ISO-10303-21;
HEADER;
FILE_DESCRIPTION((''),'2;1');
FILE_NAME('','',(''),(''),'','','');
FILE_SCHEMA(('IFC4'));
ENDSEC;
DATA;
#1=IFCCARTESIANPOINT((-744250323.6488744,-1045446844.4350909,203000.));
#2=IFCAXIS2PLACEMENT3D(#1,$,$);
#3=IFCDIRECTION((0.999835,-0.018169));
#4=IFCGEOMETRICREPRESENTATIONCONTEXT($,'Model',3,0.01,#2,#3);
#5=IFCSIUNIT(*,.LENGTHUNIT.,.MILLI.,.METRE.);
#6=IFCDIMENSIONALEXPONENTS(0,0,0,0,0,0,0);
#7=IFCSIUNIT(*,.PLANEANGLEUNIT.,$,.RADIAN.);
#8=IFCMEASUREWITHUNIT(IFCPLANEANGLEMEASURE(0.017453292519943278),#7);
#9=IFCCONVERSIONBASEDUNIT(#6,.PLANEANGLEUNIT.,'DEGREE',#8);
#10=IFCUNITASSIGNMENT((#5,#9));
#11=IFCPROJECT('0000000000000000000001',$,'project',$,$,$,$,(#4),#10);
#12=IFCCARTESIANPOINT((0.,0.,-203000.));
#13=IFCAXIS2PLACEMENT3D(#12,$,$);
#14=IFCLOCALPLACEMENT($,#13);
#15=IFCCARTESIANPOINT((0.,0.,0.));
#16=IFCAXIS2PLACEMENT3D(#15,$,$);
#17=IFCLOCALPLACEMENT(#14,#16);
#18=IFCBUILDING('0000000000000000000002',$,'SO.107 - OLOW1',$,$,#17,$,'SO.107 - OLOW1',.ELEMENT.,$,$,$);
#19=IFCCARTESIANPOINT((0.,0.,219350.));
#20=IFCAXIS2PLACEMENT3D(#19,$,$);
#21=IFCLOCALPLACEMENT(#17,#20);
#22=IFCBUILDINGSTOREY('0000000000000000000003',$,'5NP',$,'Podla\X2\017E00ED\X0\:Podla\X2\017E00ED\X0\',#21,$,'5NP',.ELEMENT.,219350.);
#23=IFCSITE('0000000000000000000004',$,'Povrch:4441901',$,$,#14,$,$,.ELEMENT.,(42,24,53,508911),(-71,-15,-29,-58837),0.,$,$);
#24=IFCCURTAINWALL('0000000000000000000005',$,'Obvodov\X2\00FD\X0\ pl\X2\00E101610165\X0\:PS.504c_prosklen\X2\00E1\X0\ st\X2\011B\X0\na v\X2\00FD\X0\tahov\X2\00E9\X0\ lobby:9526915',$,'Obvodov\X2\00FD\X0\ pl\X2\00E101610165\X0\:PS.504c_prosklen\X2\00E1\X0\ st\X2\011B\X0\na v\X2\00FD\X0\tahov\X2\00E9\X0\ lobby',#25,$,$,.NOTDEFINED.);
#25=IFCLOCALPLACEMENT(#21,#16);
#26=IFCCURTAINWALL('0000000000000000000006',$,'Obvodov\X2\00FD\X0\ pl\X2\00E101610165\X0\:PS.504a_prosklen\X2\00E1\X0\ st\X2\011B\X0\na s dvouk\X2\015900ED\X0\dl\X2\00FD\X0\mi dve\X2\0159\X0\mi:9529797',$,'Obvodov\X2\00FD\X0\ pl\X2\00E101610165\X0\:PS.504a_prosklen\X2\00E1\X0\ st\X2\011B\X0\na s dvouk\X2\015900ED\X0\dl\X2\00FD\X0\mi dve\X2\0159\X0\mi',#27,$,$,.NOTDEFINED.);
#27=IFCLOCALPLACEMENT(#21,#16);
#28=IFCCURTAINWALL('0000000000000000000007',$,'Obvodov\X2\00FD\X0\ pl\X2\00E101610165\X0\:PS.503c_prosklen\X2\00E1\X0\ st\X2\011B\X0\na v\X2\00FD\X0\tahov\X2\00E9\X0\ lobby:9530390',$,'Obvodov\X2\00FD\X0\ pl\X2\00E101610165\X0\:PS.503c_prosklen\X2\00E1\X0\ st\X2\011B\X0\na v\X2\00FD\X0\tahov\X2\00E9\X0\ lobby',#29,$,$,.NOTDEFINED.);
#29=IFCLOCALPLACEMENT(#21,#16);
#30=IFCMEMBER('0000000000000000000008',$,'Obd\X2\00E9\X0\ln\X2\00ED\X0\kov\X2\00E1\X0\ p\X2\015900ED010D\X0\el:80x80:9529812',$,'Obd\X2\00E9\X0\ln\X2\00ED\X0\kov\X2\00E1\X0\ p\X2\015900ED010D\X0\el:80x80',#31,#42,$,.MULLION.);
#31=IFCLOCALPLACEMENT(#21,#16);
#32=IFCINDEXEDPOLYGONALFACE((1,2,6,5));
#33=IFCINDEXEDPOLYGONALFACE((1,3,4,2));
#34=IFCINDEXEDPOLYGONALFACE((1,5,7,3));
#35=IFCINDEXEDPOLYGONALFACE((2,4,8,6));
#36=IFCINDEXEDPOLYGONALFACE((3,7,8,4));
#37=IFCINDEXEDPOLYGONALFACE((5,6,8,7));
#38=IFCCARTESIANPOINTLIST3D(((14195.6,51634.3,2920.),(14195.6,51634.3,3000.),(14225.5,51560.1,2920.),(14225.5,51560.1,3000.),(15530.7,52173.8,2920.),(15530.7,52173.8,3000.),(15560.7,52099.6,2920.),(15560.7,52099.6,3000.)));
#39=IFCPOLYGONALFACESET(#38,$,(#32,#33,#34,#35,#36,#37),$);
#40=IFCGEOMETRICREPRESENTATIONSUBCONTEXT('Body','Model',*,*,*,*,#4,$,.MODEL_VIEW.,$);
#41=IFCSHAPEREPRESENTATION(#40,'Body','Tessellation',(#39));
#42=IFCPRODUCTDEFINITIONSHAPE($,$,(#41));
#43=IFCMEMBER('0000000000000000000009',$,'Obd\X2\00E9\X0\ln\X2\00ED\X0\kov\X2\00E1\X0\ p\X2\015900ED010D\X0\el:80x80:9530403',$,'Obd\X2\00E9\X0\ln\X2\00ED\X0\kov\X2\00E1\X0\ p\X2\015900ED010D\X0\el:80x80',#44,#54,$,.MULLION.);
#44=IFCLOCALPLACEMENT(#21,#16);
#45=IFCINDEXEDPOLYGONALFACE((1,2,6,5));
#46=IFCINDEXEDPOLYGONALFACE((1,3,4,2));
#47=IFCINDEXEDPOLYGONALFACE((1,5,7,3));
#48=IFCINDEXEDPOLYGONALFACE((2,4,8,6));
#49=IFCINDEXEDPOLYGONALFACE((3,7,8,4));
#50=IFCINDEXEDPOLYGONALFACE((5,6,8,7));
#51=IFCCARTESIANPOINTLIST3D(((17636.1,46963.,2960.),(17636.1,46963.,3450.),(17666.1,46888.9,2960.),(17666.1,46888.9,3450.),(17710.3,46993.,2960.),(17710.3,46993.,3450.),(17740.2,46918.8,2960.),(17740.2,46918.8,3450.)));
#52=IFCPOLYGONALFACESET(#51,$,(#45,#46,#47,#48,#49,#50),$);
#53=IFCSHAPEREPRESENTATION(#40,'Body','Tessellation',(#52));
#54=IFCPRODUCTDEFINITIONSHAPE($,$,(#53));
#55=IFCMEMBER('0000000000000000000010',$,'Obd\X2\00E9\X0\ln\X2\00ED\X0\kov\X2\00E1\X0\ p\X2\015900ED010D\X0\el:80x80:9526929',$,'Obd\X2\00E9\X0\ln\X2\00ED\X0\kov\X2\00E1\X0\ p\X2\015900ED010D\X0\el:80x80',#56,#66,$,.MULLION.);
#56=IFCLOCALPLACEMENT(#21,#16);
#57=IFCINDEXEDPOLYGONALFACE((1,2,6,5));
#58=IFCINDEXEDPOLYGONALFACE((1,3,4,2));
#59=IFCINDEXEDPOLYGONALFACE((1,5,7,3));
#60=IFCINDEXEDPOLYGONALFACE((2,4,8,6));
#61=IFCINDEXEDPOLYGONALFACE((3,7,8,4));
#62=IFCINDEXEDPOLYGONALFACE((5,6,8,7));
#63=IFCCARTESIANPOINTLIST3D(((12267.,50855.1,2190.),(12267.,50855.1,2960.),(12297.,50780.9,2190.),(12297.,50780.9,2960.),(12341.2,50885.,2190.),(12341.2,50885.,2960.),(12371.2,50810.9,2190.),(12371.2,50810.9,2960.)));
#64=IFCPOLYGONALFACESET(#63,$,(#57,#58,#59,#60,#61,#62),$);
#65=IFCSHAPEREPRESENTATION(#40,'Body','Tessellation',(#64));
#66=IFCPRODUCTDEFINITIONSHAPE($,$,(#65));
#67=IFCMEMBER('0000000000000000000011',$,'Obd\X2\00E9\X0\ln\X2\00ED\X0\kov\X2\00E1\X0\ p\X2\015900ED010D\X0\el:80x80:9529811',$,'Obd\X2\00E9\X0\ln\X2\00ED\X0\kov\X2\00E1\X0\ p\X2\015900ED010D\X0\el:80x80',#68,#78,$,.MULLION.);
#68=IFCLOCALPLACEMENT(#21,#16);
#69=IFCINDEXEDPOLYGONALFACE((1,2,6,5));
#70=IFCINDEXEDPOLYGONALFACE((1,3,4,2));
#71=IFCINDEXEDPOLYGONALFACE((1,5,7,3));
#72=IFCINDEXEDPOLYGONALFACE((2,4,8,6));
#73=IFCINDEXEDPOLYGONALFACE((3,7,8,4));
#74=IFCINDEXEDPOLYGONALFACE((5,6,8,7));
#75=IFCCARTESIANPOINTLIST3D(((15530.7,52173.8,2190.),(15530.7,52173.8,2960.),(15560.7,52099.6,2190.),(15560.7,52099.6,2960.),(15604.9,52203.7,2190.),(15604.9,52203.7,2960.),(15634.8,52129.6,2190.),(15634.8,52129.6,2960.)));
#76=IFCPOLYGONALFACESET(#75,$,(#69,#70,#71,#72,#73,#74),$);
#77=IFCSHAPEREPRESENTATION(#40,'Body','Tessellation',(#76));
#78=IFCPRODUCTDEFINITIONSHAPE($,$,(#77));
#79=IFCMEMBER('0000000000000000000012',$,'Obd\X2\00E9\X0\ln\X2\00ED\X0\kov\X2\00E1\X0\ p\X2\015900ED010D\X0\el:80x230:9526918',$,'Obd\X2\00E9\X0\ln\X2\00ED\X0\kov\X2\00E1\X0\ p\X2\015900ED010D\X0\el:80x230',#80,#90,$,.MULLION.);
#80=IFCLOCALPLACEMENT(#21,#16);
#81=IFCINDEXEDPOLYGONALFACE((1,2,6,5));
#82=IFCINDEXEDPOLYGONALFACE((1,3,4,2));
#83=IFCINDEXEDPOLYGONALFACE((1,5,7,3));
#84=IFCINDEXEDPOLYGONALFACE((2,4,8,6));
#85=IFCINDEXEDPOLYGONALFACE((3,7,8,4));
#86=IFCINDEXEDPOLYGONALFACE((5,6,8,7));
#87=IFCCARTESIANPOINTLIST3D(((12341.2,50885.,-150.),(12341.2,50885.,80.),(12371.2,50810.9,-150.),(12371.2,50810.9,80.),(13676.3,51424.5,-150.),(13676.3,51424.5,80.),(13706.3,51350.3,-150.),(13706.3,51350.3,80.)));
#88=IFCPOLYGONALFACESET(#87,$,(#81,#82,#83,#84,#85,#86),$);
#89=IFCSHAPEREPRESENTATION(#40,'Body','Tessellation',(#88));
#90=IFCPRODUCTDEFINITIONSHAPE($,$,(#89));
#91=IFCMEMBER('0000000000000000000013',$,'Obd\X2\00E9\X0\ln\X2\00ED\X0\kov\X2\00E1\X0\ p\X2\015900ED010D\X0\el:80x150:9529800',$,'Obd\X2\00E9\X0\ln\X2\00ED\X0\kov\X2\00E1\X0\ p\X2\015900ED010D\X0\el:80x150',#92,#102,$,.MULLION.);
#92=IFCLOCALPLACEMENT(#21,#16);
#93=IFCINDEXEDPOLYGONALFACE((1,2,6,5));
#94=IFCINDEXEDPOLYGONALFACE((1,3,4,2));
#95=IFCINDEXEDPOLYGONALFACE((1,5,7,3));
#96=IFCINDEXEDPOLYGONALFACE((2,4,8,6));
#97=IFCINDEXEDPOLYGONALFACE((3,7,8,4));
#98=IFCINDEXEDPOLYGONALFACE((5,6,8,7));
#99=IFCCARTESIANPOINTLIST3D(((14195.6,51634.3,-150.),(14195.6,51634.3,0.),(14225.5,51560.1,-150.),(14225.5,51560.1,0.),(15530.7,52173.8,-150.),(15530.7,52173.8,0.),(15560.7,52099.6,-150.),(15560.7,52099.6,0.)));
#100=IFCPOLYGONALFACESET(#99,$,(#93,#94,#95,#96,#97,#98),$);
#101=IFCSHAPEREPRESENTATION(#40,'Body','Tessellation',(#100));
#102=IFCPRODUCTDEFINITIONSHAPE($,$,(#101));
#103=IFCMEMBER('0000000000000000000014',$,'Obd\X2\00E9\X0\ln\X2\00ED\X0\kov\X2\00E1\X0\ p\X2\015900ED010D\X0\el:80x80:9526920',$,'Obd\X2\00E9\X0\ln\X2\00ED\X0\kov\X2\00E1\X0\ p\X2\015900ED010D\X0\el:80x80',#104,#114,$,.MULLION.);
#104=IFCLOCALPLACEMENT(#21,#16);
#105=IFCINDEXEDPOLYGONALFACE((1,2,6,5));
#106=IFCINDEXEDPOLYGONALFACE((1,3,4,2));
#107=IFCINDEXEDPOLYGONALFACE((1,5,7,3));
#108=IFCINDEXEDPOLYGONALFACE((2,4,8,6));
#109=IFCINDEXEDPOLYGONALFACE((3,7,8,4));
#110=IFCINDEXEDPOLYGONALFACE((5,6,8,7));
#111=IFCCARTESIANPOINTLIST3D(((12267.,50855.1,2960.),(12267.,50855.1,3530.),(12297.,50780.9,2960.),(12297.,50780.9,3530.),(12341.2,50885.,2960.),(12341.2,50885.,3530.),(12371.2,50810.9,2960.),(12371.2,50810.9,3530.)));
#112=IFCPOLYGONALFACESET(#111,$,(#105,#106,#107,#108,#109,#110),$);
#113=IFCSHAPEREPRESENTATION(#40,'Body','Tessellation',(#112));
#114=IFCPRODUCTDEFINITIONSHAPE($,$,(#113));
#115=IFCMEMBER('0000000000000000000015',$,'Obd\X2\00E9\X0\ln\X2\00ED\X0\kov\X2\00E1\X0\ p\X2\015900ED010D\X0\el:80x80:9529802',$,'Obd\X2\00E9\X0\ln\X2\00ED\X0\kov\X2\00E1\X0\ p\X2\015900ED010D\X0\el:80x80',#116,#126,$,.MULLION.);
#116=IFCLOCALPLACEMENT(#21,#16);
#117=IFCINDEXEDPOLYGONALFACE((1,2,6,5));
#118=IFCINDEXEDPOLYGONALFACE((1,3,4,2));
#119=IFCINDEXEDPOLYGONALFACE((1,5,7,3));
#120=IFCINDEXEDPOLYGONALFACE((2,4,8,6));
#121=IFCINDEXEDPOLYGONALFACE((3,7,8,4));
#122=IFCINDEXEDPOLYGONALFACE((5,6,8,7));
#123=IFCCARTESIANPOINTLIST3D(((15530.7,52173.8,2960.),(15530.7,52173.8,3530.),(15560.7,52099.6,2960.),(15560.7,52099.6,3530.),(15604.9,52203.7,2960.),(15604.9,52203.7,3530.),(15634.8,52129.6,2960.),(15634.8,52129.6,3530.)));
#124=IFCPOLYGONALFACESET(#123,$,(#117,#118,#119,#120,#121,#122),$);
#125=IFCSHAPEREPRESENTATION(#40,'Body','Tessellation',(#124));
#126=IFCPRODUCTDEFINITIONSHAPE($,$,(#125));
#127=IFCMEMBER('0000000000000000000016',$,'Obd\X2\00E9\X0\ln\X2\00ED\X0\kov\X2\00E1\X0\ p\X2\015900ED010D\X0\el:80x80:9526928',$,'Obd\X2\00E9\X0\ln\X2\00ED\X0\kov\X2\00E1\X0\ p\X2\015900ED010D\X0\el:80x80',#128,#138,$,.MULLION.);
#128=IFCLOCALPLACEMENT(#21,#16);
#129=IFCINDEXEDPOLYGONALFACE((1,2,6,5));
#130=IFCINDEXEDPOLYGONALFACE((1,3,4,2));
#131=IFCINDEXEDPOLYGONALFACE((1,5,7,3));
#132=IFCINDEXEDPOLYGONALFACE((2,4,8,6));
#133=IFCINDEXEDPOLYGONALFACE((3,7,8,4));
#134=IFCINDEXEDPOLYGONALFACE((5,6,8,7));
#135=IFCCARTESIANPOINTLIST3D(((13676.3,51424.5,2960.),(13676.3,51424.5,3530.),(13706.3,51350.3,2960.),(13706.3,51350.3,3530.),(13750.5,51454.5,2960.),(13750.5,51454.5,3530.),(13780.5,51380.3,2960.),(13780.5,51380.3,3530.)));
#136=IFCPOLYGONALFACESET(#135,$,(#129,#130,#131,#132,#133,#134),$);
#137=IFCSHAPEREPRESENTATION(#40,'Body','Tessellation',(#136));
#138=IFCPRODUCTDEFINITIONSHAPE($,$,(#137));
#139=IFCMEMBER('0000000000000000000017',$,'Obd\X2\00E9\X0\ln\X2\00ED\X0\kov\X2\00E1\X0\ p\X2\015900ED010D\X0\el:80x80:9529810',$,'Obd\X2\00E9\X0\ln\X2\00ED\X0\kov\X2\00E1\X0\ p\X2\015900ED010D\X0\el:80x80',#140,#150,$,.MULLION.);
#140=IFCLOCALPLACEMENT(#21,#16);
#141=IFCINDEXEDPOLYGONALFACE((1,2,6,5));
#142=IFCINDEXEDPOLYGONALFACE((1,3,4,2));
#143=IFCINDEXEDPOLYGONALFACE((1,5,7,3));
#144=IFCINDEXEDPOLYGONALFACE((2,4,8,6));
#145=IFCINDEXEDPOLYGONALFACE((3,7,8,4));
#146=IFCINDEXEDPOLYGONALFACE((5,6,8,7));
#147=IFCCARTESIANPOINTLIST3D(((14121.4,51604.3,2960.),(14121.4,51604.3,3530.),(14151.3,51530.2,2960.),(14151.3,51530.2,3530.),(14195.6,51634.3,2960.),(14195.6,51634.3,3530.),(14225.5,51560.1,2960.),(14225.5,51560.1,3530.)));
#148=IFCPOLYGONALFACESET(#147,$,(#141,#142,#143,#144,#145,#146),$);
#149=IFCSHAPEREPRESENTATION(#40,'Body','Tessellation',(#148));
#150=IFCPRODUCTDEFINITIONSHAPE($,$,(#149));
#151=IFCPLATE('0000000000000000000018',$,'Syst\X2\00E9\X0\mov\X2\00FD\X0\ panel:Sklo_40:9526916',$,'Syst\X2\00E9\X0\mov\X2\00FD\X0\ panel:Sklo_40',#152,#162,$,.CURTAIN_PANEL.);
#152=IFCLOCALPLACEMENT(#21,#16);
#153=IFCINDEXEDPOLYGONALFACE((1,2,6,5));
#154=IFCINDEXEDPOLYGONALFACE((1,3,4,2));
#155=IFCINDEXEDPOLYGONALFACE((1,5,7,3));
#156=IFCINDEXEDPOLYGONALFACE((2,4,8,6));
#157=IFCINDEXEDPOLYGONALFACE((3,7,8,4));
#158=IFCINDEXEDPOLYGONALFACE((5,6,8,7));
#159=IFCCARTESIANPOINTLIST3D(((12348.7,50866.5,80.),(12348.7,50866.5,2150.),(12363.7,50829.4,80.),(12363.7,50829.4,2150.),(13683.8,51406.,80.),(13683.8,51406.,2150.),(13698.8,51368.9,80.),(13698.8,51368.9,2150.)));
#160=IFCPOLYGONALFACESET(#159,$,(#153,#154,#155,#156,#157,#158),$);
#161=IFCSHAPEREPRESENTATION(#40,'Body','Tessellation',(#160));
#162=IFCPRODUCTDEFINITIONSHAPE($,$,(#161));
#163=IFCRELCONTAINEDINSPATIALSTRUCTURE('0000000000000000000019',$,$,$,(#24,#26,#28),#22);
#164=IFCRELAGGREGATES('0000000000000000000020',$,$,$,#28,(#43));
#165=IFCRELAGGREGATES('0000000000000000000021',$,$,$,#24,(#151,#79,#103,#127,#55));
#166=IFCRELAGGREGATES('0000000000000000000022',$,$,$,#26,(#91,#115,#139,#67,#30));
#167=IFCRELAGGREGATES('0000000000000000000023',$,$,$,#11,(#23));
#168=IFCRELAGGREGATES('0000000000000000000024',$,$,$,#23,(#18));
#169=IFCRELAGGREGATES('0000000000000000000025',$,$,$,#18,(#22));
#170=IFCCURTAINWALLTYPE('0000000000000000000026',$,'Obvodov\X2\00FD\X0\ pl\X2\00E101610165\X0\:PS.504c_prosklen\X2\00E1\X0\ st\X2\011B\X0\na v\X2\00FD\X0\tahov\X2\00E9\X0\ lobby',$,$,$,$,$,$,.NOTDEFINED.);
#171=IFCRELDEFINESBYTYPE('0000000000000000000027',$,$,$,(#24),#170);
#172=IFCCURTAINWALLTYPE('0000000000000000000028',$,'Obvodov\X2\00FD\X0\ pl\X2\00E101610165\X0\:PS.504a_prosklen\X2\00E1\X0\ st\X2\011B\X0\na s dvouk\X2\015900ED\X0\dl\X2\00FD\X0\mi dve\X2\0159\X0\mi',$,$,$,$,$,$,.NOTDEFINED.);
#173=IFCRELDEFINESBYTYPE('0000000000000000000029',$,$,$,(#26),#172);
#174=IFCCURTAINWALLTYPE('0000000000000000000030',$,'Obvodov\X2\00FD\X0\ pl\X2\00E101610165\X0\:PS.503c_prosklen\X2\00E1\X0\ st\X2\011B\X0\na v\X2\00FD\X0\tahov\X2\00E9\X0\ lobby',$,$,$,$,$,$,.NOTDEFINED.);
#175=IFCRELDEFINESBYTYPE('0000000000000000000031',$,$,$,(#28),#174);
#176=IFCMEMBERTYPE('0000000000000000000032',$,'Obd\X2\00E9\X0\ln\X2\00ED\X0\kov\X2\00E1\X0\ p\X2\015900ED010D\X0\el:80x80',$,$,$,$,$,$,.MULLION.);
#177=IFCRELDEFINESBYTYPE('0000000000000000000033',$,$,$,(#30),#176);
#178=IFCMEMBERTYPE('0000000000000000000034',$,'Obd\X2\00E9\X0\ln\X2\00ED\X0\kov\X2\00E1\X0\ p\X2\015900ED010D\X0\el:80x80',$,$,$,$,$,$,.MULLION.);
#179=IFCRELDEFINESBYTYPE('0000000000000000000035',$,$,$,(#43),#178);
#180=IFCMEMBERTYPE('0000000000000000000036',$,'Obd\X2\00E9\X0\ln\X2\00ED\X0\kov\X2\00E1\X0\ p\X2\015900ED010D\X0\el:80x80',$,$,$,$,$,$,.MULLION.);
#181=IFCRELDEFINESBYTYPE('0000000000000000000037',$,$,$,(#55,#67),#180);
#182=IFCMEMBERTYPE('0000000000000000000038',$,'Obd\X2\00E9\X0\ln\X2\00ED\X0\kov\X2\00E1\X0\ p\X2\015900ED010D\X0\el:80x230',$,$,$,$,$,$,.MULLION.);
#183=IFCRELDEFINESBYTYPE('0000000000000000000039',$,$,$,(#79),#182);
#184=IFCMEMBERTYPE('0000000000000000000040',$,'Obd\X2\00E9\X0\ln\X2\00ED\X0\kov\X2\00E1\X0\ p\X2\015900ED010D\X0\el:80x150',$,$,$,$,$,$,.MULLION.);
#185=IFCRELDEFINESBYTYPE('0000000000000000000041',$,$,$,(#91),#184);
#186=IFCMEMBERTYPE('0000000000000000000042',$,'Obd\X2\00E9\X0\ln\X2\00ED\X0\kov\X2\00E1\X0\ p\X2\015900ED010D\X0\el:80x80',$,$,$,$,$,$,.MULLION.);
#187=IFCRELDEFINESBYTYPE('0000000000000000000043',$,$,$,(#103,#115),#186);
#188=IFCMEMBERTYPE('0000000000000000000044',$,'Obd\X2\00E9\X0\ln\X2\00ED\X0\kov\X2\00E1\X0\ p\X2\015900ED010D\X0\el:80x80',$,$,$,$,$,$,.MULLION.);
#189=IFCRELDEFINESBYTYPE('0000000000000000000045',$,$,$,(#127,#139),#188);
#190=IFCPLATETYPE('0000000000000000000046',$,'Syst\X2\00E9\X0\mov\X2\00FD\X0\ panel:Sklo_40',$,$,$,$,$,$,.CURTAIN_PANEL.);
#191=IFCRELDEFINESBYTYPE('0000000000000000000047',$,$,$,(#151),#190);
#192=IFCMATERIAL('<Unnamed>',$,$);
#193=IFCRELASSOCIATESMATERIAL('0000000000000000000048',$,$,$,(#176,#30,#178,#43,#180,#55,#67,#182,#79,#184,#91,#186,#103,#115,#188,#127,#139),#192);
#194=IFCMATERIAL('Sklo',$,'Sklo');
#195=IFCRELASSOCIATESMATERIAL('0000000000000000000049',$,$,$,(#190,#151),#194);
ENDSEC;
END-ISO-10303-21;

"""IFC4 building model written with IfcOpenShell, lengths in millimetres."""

from ifc_helpers import new_model, entity, si_unit, converted_unit, direction, frame, origin, place, context, subcontext, project, spatial, indexed_curve, outline, extrude, source, transform, mapped, material, type_object, type_shapes, element, aggregate, save


model = new_model("IFC4")

# Units and contexts
model_context = context("Model", 3, precision=0.01, world=frame((-744250323.6488744, -1045446844.4350909, 203000.0)), true_north=direction((0.999835, -0.018169)))
body_context = subcontext(model_context, "Body", "Model", "MODEL_VIEW")
ifc_project = project(units=[si_unit("LENGTHUNIT", "METRE", prefix="MILLI"), converted_unit("PLANEANGLEUNIT", "DEGREE", entity("IfcPlaneAngleMeasure", 0.017453292519943278), si_unit("PLANEANGLEUNIT", "RADIAN"), dimensions=[0, 0, 0, 0, 0, 0, 0])], contexts=[model_context])

# Site, building, storey
site_placement = place(None, frame((0.0, 0.0, -203000.0)))
site = spatial("IfcSite", under=ifc_project, at=site_placement, Name="Povrch:4441901", CompositionType="ELEMENT", RefLatitude=(42, 24, 53, 508911), RefLongitude=(-71, -15, -29, -58837), RefElevation=0.0)
building_placement = place(site_placement, origin())
building = spatial("IfcBuilding", under=site, at=building_placement, Name="SO.107 - OLOW1", LongName="SO.107 - OLOW1", CompositionType="ELEMENT")
storey_placement = place(building_placement, frame((0.0, 0.0, 219350.0)))
storey = spatial("IfcBuildingStorey", under=building, at=storey_placement, Name="5NP", ObjectType="Podlaží:Podlaží", LongName="5NP", CompositionType="ELEMENT", Elevation=219350.0)

# Curtain walls
curtain_wall_type_1 = type_object("IfcCurtainWallType", Name="Obvodový plášť:PS.504c_prosklená stěna výtahové lobby", PredefinedType="NOTDEFINED")
curtain_wall_1_placement = place(storey_placement, frame((0.0, 0.0, -219350.0)))
curtain_wall_1 = element("IfcCurtainWall", 1, at=curtain_wall_1_placement, inside=storey, type_object=curtain_wall_type_1, Name="Obvodový plášť:PS.504c_prosklená stěna výtahové lobby:9526915", ObjectType="Obvodový plášť:PS.504c_prosklená stěna výtahové lobby", PredefinedType="NOTDEFINED")
ifc_material_1 = material(Name="<Unnamed>")
curtain_wall_type_2 = type_object("IfcCurtainWallType", Name="Obvodový plášť:PS.504a_prosklená stěna s dvoukřídlými dveřmi", PredefinedType="NOTDEFINED")
curtain_wall_2_placement = place(storey_placement, frame((0.0, 0.0, -219350.0)))
curtain_wall_2 = element("IfcCurtainWall", 2, at=curtain_wall_2_placement, inside=storey, type_object=curtain_wall_type_2, Name="Obvodový plášť:PS.504a_prosklená stěna s dvoukřídlými dveřmi:9529797", ObjectType="Obvodový plášť:PS.504a_prosklená stěna s dvoukřídlými dveřmi", PredefinedType="NOTDEFINED")

# Curtain wall
curtain_wall_type_3 = type_object("IfcCurtainWallType", Name="Obvodový plášť:PS.503c_prosklená stěna výtahové lobby", PredefinedType="NOTDEFINED")
curtain_wall_3_placement = place(storey_placement, frame((0.0, 0.0, -219350.0)))
curtain_wall_3 = element("IfcCurtainWall", 3, at=curtain_wall_3_placement, inside=storey, type_object=curtain_wall_type_3, Name="Obvodový plášť:PS.503c_prosklená stěna výtahové lobby:9530390", ObjectType="Obvodový plášť:PS.503c_prosklená stěna výtahové lobby", PredefinedType="NOTDEFINED")

# Members
member_type_1 = type_object("IfcMemberType", Name="Obdélníková příčel:80x80", PredefinedType="MULLION", material=ifc_material_1)
shared_shape_1 = source(origin(), body_context, "Body", "SweptSolid", [
    extrude(outline(indexed_curve([(-40.0, -40.0), (40.0, -40.0), (40.0, 40.0), (-40.0, 40.0), (-40.0, -40.0)], self_intersect=False)), frame((0.0, 0.0, -1440.0), z_axis=(0.0, 0.0, 1.0), x_axis=(-1.0, 0.0, 0.0)), (0.0, 0.0, 1.0), 1440.0),
])
type_shapes(member_type_1, [shared_shape_1])
member_1_placement = place(curtain_wall_2_placement, frame((14210.5, 51597.2, 222310.0), z_axis=(-0.927176, -0.374626, 0.0), x_axis=(0.0, 0.0, 1.0)))
member_1 = element("IfcMember", 4, at=member_1_placement, type_object=member_type_1, material=ifc_material_1, Name="Obdélníková příčel:80x80:9529812", ObjectType="Obdélníková příčel:80x80", PredefinedType="MULLION", context=body_context, shape_type="MappedRepresentation", body=[
    mapped(shared_shape_1, transform((0.0, 0.0, 0.0), scale=1.0)),
])
member_type_2 = type_object("IfcMemberType", Name="Obdélníková příčel:80x80", PredefinedType="MULLION", material=ifc_material_1)
shared_shape_2 = source(origin(), body_context, "Body", "SweptSolid", [
    extrude(outline(indexed_curve([(-40.0, -40.0), (40.0, -40.0), (40.0, 40.0), (-40.0, 40.0), (-40.0, -40.0)], self_intersect=False)), frame((-40.0, 0.0, -490.0), z_axis=(0.0, 0.0, 1.0), x_axis=(-1.0, 0.0, 0.0)), (0.0, 0.0, 1.0), 490.0),
])
type_shapes(member_type_2, [shared_shape_2])
member_2_placement = place(curtain_wall_3_placement, frame((17725.2, 46955.9, 222310.0), z_axis=(0.0, 0.0, -1.0), x_axis=(0.927176, 0.374626, 0.0)))
member_2 = element("IfcMember", 5, at=member_2_placement, type_object=member_type_2, material=ifc_material_1, Name="Obdélníková příčel:80x80:9530403", ObjectType="Obdélníková příčel:80x80", PredefinedType="MULLION", context=body_context, shape_type="MappedRepresentation", body=[
    mapped(shared_shape_2, transform((0.0, 0.0, 0.0), scale=1.0)),
])
aggregate(curtain_wall_3, [member_2])
member_type_3 = type_object("IfcMemberType", Name="Obdélníková příčel:80x80", PredefinedType="MULLION", material=ifc_material_1)
shared_shape_3 = source(origin(), body_context, "Body", "SweptSolid", [
    extrude(outline(indexed_curve([(-40.0, -40.0), (40.0, -40.0), (40.0, 40.0), (-40.0, 40.0), (-40.0, -40.0)], self_intersect=False)), frame((-40.0, 0.0, -770.0), z_axis=(0.0, 0.0, 1.0), x_axis=(-1.0, 0.0, 0.0)), (0.0, 0.0, 1.0), 770.0),
])
type_shapes(member_type_3, [shared_shape_3])
member_3_placement = place(curtain_wall_1_placement, frame((12282.0, 50818.0, 222310.0), z_axis=(0.0, 0.0, 1.0), x_axis=(-0.927176, -0.374626, 0.0)))
member_3 = element("IfcMember", 6, at=member_3_placement, type_object=member_type_3, material=ifc_material_1, Name="Obdélníková příčel:80x80:9526929", ObjectType="Obdélníková příčel:80x80", PredefinedType="MULLION", context=body_context, shape_type="MappedRepresentation", body=[
    mapped(shared_shape_3, transform((0.0, 0.0, 0.0), scale=1.0)),
])
member_4_placement = place(curtain_wall_2_placement, frame((15619.8, 52166.6, 222310.0), z_axis=(0.0, 0.0, 1.0), x_axis=(0.927176, 0.374626, 0.0)))
member_4 = element("IfcMember", 7, at=member_4_placement, type_object=member_type_3, material=ifc_material_1, Name="Obdélníková příčel:80x80:9529811", ObjectType="Obdélníková příčel:80x80", PredefinedType="MULLION", context=body_context, shape_type="MappedRepresentation", body=[
    mapped(shared_shape_3, transform((0.0, 0.0, 0.0), scale=1.0)),
])
member_type_4 = type_object("IfcMemberType", Name="Obdélníková příčel:80x230", PredefinedType="MULLION", material=ifc_material_1)
shared_shape_4 = source(origin(), body_context, "Body", "SweptSolid", [
    extrude(outline(indexed_curve([(-115.0, -40.0), (115.0, -40.0), (115.0, 40.0), (-115.0, 40.0), (-115.0, -40.0)], self_intersect=False)), frame((-115.0, 0.0, -1440.0), z_axis=(0.0, 0.0, 1.0), x_axis=(-1.0, 0.0, 0.0)), (0.0, 0.0, 1.0), 1440.0),
])
type_shapes(member_type_4, [shared_shape_4])
member_5_placement = place(curtain_wall_1_placement, frame((12356.2, 50848.0, 219200.0), z_axis=(-0.927176, -0.374626, 0.0), x_axis=(0.0, 0.0, -1.0)))
member_5 = element("IfcMember", 8, at=member_5_placement, type_object=member_type_4, material=ifc_material_1, Name="Obdélníková příčel:80x230:9526918", ObjectType="Obdélníková příčel:80x230", PredefinedType="MULLION", context=body_context, shape_type="MappedRepresentation", body=[
    mapped(shared_shape_4, transform((0.0, 0.0, 0.0), scale=1.0)),
])
member_type_5 = type_object("IfcMemberType", Name="Obdélníková příčel:80x150", PredefinedType="MULLION", material=ifc_material_1)
shared_shape_5 = source(origin(), body_context, "Body", "SweptSolid", [
    extrude(outline(indexed_curve([(-75.0, -40.0), (75.0, -40.0), (75.0, 40.0), (-75.0, 40.0), (-75.0, -40.0)], self_intersect=False)), frame((-75.0, 0.0, -1440.0), z_axis=(0.0, 0.0, 1.0), x_axis=(-1.0, 0.0, 0.0)), (0.0, 0.0, 1.0), 1440.0),
])
type_shapes(member_type_5, [shared_shape_5])
member_6_placement = place(curtain_wall_2_placement, frame((15545.7, 52136.7, 219200.0), z_axis=(0.927176, 0.374626, 0.0), x_axis=(0.0, 0.0, -1.0)))
member_6 = element("IfcMember", 9, at=member_6_placement, type_object=member_type_5, material=ifc_material_1, Name="Obdélníková příčel:80x150:9529800", ObjectType="Obdélníková příčel:80x150", PredefinedType="MULLION", context=body_context, shape_type="MappedRepresentation", body=[
    mapped(shared_shape_5, transform((0.0, 0.0, 0.0), scale=1.0)),
])
member_type_6 = type_object("IfcMemberType", Name="Obdélníková příčel:80x80", PredefinedType="MULLION", material=ifc_material_1)
shared_shape_6 = source(origin(), body_context, "Body", "SweptSolid", [
    extrude(outline(indexed_curve([(-40.0, -40.0), (40.0, -40.0), (40.0, 40.0), (-40.0, 40.0), (-40.0, -40.0)], self_intersect=False)), frame((-40.0, 0.0, -570.0), z_axis=(0.0, 0.0, 1.0), x_axis=(-1.0, 0.0, 0.0)), (0.0, 0.0, 1.0), 570.0),
])
type_shapes(member_type_6, [shared_shape_6])
member_7_placement = place(curtain_wall_1_placement, frame((12282.0, 50818.0, 222880.0), z_axis=(0.0, 0.0, 1.0), x_axis=(-0.927176, -0.374626, 0.0)))
member_7 = element("IfcMember", 10, at=member_7_placement, type_object=member_type_6, material=ifc_material_1, Name="Obdélníková příčel:80x80:9526920", ObjectType="Obdélníková příčel:80x80", PredefinedType="MULLION", context=body_context, shape_type="MappedRepresentation", body=[
    mapped(shared_shape_6, transform((0.0, 0.0, 0.0), scale=1.0)),
])
member_8_placement = place(curtain_wall_2_placement, frame((15619.8, 52166.6, 222880.0), z_axis=(0.0, 0.0, 1.0), x_axis=(0.927176, 0.374626, 0.0)))
member_8 = element("IfcMember", 11, at=member_8_placement, type_object=member_type_6, material=ifc_material_1, Name="Obdélníková příčel:80x80:9529802", ObjectType="Obdélníková příčel:80x80", PredefinedType="MULLION", context=body_context, shape_type="MappedRepresentation", body=[
    mapped(shared_shape_6, transform((0.0, 0.0, 0.0), scale=1.0)),
])
member_type_7 = type_object("IfcMemberType", Name="Obdélníková příčel:80x80", PredefinedType="MULLION", material=ifc_material_1)
shared_shape_7 = source(origin(), body_context, "Body", "SweptSolid", [
    extrude(outline(indexed_curve([(-40.0, -40.0), (40.0, -40.0), (40.0, 40.0), (-40.0, 40.0), (-40.0, -40.0)], self_intersect=False)), frame((-40.0, 0.0, -570.0), z_axis=(0.0, 0.0, 1.0), x_axis=(-1.0, 0.0, 0.0)), (0.0, 0.0, 1.0), 570.0),
])
type_shapes(member_type_7, [shared_shape_7])
member_9_placement = place(curtain_wall_1_placement, frame((13765.5, 51417.4, 222310.0), z_axis=(0.0, 0.0, -1.0), x_axis=(0.927176, 0.374626, 0.0)))
member_9 = element("IfcMember", 12, at=member_9_placement, type_object=member_type_7, material=ifc_material_1, Name="Obdélníková příčel:80x80:9526928", ObjectType="Obdélníková příčel:80x80", PredefinedType="MULLION", context=body_context, shape_type="MappedRepresentation", body=[
    mapped(shared_shape_7, transform((0.0, 0.0, 0.0), scale=1.0)),
])
member_10_placement = place(curtain_wall_2_placement, frame((14136.4, 51567.2, 222310.0), z_axis=(0.0, 0.0, -1.0), x_axis=(-0.927176, -0.374626, 0.0)))
member_10 = element("IfcMember", 13, at=member_10_placement, type_object=member_type_7, material=ifc_material_1, Name="Obdélníková příčel:80x80:9529810", ObjectType="Obdélníková příčel:80x80", PredefinedType="MULLION", context=body_context, shape_type="MappedRepresentation", body=[
    mapped(shared_shape_7, transform((0.0, 0.0, 0.0), scale=1.0)),
])

# Plate
ifc_material_2 = material(Name="Sklo", Category="Sklo")
plate_type_1 = type_object("IfcPlateType", Name="Systémový panel:Sklo_40", PredefinedType="CURTAIN_PANEL", material=ifc_material_2)
shared_shape_8 = source(origin(), body_context, "Body", "SweptSolid", [
    extrude(outline(indexed_curve([(-20.0, -720.0), (20.0, -720.0), (20.0, 720.0), (-20.0, 720.0), (-20.0, -720.0)], self_intersect=False)), frame((0.0, 0.0, 0.0), z_axis=(0.0, 0.0, 1.0), x_axis=(0.0, 1.0, 0.0)), (0.0, 0.0, 1.0), 2070.0),
])
type_shapes(plate_type_1, [shared_shape_8])
plate_1_placement = place(curtain_wall_1_placement, frame((13023.8, 51117.7, 219430.0), z_axis=(0.0, 0.0, 1.0), x_axis=(0.927176, 0.374626, 0.0)))
plate_1 = element("IfcPlate", 14, at=plate_1_placement, type_object=plate_type_1, material=ifc_material_2, Name="Systémový panel:Sklo_40:9526916", ObjectType="Systémový panel:Sklo_40", PredefinedType="CURTAIN_PANEL", context=body_context, shape_type="MappedRepresentation", body=[
    mapped(shared_shape_8, transform((0.0, 0.0, 0.0), scale=1.0)),
])
aggregate(curtain_wall_1, [plate_1, member_5, member_7, member_9, member_3])

aggregate(curtain_wall_2, [member_6, member_8, member_10, member_4, member_1])

save(model, "model.ifc")
